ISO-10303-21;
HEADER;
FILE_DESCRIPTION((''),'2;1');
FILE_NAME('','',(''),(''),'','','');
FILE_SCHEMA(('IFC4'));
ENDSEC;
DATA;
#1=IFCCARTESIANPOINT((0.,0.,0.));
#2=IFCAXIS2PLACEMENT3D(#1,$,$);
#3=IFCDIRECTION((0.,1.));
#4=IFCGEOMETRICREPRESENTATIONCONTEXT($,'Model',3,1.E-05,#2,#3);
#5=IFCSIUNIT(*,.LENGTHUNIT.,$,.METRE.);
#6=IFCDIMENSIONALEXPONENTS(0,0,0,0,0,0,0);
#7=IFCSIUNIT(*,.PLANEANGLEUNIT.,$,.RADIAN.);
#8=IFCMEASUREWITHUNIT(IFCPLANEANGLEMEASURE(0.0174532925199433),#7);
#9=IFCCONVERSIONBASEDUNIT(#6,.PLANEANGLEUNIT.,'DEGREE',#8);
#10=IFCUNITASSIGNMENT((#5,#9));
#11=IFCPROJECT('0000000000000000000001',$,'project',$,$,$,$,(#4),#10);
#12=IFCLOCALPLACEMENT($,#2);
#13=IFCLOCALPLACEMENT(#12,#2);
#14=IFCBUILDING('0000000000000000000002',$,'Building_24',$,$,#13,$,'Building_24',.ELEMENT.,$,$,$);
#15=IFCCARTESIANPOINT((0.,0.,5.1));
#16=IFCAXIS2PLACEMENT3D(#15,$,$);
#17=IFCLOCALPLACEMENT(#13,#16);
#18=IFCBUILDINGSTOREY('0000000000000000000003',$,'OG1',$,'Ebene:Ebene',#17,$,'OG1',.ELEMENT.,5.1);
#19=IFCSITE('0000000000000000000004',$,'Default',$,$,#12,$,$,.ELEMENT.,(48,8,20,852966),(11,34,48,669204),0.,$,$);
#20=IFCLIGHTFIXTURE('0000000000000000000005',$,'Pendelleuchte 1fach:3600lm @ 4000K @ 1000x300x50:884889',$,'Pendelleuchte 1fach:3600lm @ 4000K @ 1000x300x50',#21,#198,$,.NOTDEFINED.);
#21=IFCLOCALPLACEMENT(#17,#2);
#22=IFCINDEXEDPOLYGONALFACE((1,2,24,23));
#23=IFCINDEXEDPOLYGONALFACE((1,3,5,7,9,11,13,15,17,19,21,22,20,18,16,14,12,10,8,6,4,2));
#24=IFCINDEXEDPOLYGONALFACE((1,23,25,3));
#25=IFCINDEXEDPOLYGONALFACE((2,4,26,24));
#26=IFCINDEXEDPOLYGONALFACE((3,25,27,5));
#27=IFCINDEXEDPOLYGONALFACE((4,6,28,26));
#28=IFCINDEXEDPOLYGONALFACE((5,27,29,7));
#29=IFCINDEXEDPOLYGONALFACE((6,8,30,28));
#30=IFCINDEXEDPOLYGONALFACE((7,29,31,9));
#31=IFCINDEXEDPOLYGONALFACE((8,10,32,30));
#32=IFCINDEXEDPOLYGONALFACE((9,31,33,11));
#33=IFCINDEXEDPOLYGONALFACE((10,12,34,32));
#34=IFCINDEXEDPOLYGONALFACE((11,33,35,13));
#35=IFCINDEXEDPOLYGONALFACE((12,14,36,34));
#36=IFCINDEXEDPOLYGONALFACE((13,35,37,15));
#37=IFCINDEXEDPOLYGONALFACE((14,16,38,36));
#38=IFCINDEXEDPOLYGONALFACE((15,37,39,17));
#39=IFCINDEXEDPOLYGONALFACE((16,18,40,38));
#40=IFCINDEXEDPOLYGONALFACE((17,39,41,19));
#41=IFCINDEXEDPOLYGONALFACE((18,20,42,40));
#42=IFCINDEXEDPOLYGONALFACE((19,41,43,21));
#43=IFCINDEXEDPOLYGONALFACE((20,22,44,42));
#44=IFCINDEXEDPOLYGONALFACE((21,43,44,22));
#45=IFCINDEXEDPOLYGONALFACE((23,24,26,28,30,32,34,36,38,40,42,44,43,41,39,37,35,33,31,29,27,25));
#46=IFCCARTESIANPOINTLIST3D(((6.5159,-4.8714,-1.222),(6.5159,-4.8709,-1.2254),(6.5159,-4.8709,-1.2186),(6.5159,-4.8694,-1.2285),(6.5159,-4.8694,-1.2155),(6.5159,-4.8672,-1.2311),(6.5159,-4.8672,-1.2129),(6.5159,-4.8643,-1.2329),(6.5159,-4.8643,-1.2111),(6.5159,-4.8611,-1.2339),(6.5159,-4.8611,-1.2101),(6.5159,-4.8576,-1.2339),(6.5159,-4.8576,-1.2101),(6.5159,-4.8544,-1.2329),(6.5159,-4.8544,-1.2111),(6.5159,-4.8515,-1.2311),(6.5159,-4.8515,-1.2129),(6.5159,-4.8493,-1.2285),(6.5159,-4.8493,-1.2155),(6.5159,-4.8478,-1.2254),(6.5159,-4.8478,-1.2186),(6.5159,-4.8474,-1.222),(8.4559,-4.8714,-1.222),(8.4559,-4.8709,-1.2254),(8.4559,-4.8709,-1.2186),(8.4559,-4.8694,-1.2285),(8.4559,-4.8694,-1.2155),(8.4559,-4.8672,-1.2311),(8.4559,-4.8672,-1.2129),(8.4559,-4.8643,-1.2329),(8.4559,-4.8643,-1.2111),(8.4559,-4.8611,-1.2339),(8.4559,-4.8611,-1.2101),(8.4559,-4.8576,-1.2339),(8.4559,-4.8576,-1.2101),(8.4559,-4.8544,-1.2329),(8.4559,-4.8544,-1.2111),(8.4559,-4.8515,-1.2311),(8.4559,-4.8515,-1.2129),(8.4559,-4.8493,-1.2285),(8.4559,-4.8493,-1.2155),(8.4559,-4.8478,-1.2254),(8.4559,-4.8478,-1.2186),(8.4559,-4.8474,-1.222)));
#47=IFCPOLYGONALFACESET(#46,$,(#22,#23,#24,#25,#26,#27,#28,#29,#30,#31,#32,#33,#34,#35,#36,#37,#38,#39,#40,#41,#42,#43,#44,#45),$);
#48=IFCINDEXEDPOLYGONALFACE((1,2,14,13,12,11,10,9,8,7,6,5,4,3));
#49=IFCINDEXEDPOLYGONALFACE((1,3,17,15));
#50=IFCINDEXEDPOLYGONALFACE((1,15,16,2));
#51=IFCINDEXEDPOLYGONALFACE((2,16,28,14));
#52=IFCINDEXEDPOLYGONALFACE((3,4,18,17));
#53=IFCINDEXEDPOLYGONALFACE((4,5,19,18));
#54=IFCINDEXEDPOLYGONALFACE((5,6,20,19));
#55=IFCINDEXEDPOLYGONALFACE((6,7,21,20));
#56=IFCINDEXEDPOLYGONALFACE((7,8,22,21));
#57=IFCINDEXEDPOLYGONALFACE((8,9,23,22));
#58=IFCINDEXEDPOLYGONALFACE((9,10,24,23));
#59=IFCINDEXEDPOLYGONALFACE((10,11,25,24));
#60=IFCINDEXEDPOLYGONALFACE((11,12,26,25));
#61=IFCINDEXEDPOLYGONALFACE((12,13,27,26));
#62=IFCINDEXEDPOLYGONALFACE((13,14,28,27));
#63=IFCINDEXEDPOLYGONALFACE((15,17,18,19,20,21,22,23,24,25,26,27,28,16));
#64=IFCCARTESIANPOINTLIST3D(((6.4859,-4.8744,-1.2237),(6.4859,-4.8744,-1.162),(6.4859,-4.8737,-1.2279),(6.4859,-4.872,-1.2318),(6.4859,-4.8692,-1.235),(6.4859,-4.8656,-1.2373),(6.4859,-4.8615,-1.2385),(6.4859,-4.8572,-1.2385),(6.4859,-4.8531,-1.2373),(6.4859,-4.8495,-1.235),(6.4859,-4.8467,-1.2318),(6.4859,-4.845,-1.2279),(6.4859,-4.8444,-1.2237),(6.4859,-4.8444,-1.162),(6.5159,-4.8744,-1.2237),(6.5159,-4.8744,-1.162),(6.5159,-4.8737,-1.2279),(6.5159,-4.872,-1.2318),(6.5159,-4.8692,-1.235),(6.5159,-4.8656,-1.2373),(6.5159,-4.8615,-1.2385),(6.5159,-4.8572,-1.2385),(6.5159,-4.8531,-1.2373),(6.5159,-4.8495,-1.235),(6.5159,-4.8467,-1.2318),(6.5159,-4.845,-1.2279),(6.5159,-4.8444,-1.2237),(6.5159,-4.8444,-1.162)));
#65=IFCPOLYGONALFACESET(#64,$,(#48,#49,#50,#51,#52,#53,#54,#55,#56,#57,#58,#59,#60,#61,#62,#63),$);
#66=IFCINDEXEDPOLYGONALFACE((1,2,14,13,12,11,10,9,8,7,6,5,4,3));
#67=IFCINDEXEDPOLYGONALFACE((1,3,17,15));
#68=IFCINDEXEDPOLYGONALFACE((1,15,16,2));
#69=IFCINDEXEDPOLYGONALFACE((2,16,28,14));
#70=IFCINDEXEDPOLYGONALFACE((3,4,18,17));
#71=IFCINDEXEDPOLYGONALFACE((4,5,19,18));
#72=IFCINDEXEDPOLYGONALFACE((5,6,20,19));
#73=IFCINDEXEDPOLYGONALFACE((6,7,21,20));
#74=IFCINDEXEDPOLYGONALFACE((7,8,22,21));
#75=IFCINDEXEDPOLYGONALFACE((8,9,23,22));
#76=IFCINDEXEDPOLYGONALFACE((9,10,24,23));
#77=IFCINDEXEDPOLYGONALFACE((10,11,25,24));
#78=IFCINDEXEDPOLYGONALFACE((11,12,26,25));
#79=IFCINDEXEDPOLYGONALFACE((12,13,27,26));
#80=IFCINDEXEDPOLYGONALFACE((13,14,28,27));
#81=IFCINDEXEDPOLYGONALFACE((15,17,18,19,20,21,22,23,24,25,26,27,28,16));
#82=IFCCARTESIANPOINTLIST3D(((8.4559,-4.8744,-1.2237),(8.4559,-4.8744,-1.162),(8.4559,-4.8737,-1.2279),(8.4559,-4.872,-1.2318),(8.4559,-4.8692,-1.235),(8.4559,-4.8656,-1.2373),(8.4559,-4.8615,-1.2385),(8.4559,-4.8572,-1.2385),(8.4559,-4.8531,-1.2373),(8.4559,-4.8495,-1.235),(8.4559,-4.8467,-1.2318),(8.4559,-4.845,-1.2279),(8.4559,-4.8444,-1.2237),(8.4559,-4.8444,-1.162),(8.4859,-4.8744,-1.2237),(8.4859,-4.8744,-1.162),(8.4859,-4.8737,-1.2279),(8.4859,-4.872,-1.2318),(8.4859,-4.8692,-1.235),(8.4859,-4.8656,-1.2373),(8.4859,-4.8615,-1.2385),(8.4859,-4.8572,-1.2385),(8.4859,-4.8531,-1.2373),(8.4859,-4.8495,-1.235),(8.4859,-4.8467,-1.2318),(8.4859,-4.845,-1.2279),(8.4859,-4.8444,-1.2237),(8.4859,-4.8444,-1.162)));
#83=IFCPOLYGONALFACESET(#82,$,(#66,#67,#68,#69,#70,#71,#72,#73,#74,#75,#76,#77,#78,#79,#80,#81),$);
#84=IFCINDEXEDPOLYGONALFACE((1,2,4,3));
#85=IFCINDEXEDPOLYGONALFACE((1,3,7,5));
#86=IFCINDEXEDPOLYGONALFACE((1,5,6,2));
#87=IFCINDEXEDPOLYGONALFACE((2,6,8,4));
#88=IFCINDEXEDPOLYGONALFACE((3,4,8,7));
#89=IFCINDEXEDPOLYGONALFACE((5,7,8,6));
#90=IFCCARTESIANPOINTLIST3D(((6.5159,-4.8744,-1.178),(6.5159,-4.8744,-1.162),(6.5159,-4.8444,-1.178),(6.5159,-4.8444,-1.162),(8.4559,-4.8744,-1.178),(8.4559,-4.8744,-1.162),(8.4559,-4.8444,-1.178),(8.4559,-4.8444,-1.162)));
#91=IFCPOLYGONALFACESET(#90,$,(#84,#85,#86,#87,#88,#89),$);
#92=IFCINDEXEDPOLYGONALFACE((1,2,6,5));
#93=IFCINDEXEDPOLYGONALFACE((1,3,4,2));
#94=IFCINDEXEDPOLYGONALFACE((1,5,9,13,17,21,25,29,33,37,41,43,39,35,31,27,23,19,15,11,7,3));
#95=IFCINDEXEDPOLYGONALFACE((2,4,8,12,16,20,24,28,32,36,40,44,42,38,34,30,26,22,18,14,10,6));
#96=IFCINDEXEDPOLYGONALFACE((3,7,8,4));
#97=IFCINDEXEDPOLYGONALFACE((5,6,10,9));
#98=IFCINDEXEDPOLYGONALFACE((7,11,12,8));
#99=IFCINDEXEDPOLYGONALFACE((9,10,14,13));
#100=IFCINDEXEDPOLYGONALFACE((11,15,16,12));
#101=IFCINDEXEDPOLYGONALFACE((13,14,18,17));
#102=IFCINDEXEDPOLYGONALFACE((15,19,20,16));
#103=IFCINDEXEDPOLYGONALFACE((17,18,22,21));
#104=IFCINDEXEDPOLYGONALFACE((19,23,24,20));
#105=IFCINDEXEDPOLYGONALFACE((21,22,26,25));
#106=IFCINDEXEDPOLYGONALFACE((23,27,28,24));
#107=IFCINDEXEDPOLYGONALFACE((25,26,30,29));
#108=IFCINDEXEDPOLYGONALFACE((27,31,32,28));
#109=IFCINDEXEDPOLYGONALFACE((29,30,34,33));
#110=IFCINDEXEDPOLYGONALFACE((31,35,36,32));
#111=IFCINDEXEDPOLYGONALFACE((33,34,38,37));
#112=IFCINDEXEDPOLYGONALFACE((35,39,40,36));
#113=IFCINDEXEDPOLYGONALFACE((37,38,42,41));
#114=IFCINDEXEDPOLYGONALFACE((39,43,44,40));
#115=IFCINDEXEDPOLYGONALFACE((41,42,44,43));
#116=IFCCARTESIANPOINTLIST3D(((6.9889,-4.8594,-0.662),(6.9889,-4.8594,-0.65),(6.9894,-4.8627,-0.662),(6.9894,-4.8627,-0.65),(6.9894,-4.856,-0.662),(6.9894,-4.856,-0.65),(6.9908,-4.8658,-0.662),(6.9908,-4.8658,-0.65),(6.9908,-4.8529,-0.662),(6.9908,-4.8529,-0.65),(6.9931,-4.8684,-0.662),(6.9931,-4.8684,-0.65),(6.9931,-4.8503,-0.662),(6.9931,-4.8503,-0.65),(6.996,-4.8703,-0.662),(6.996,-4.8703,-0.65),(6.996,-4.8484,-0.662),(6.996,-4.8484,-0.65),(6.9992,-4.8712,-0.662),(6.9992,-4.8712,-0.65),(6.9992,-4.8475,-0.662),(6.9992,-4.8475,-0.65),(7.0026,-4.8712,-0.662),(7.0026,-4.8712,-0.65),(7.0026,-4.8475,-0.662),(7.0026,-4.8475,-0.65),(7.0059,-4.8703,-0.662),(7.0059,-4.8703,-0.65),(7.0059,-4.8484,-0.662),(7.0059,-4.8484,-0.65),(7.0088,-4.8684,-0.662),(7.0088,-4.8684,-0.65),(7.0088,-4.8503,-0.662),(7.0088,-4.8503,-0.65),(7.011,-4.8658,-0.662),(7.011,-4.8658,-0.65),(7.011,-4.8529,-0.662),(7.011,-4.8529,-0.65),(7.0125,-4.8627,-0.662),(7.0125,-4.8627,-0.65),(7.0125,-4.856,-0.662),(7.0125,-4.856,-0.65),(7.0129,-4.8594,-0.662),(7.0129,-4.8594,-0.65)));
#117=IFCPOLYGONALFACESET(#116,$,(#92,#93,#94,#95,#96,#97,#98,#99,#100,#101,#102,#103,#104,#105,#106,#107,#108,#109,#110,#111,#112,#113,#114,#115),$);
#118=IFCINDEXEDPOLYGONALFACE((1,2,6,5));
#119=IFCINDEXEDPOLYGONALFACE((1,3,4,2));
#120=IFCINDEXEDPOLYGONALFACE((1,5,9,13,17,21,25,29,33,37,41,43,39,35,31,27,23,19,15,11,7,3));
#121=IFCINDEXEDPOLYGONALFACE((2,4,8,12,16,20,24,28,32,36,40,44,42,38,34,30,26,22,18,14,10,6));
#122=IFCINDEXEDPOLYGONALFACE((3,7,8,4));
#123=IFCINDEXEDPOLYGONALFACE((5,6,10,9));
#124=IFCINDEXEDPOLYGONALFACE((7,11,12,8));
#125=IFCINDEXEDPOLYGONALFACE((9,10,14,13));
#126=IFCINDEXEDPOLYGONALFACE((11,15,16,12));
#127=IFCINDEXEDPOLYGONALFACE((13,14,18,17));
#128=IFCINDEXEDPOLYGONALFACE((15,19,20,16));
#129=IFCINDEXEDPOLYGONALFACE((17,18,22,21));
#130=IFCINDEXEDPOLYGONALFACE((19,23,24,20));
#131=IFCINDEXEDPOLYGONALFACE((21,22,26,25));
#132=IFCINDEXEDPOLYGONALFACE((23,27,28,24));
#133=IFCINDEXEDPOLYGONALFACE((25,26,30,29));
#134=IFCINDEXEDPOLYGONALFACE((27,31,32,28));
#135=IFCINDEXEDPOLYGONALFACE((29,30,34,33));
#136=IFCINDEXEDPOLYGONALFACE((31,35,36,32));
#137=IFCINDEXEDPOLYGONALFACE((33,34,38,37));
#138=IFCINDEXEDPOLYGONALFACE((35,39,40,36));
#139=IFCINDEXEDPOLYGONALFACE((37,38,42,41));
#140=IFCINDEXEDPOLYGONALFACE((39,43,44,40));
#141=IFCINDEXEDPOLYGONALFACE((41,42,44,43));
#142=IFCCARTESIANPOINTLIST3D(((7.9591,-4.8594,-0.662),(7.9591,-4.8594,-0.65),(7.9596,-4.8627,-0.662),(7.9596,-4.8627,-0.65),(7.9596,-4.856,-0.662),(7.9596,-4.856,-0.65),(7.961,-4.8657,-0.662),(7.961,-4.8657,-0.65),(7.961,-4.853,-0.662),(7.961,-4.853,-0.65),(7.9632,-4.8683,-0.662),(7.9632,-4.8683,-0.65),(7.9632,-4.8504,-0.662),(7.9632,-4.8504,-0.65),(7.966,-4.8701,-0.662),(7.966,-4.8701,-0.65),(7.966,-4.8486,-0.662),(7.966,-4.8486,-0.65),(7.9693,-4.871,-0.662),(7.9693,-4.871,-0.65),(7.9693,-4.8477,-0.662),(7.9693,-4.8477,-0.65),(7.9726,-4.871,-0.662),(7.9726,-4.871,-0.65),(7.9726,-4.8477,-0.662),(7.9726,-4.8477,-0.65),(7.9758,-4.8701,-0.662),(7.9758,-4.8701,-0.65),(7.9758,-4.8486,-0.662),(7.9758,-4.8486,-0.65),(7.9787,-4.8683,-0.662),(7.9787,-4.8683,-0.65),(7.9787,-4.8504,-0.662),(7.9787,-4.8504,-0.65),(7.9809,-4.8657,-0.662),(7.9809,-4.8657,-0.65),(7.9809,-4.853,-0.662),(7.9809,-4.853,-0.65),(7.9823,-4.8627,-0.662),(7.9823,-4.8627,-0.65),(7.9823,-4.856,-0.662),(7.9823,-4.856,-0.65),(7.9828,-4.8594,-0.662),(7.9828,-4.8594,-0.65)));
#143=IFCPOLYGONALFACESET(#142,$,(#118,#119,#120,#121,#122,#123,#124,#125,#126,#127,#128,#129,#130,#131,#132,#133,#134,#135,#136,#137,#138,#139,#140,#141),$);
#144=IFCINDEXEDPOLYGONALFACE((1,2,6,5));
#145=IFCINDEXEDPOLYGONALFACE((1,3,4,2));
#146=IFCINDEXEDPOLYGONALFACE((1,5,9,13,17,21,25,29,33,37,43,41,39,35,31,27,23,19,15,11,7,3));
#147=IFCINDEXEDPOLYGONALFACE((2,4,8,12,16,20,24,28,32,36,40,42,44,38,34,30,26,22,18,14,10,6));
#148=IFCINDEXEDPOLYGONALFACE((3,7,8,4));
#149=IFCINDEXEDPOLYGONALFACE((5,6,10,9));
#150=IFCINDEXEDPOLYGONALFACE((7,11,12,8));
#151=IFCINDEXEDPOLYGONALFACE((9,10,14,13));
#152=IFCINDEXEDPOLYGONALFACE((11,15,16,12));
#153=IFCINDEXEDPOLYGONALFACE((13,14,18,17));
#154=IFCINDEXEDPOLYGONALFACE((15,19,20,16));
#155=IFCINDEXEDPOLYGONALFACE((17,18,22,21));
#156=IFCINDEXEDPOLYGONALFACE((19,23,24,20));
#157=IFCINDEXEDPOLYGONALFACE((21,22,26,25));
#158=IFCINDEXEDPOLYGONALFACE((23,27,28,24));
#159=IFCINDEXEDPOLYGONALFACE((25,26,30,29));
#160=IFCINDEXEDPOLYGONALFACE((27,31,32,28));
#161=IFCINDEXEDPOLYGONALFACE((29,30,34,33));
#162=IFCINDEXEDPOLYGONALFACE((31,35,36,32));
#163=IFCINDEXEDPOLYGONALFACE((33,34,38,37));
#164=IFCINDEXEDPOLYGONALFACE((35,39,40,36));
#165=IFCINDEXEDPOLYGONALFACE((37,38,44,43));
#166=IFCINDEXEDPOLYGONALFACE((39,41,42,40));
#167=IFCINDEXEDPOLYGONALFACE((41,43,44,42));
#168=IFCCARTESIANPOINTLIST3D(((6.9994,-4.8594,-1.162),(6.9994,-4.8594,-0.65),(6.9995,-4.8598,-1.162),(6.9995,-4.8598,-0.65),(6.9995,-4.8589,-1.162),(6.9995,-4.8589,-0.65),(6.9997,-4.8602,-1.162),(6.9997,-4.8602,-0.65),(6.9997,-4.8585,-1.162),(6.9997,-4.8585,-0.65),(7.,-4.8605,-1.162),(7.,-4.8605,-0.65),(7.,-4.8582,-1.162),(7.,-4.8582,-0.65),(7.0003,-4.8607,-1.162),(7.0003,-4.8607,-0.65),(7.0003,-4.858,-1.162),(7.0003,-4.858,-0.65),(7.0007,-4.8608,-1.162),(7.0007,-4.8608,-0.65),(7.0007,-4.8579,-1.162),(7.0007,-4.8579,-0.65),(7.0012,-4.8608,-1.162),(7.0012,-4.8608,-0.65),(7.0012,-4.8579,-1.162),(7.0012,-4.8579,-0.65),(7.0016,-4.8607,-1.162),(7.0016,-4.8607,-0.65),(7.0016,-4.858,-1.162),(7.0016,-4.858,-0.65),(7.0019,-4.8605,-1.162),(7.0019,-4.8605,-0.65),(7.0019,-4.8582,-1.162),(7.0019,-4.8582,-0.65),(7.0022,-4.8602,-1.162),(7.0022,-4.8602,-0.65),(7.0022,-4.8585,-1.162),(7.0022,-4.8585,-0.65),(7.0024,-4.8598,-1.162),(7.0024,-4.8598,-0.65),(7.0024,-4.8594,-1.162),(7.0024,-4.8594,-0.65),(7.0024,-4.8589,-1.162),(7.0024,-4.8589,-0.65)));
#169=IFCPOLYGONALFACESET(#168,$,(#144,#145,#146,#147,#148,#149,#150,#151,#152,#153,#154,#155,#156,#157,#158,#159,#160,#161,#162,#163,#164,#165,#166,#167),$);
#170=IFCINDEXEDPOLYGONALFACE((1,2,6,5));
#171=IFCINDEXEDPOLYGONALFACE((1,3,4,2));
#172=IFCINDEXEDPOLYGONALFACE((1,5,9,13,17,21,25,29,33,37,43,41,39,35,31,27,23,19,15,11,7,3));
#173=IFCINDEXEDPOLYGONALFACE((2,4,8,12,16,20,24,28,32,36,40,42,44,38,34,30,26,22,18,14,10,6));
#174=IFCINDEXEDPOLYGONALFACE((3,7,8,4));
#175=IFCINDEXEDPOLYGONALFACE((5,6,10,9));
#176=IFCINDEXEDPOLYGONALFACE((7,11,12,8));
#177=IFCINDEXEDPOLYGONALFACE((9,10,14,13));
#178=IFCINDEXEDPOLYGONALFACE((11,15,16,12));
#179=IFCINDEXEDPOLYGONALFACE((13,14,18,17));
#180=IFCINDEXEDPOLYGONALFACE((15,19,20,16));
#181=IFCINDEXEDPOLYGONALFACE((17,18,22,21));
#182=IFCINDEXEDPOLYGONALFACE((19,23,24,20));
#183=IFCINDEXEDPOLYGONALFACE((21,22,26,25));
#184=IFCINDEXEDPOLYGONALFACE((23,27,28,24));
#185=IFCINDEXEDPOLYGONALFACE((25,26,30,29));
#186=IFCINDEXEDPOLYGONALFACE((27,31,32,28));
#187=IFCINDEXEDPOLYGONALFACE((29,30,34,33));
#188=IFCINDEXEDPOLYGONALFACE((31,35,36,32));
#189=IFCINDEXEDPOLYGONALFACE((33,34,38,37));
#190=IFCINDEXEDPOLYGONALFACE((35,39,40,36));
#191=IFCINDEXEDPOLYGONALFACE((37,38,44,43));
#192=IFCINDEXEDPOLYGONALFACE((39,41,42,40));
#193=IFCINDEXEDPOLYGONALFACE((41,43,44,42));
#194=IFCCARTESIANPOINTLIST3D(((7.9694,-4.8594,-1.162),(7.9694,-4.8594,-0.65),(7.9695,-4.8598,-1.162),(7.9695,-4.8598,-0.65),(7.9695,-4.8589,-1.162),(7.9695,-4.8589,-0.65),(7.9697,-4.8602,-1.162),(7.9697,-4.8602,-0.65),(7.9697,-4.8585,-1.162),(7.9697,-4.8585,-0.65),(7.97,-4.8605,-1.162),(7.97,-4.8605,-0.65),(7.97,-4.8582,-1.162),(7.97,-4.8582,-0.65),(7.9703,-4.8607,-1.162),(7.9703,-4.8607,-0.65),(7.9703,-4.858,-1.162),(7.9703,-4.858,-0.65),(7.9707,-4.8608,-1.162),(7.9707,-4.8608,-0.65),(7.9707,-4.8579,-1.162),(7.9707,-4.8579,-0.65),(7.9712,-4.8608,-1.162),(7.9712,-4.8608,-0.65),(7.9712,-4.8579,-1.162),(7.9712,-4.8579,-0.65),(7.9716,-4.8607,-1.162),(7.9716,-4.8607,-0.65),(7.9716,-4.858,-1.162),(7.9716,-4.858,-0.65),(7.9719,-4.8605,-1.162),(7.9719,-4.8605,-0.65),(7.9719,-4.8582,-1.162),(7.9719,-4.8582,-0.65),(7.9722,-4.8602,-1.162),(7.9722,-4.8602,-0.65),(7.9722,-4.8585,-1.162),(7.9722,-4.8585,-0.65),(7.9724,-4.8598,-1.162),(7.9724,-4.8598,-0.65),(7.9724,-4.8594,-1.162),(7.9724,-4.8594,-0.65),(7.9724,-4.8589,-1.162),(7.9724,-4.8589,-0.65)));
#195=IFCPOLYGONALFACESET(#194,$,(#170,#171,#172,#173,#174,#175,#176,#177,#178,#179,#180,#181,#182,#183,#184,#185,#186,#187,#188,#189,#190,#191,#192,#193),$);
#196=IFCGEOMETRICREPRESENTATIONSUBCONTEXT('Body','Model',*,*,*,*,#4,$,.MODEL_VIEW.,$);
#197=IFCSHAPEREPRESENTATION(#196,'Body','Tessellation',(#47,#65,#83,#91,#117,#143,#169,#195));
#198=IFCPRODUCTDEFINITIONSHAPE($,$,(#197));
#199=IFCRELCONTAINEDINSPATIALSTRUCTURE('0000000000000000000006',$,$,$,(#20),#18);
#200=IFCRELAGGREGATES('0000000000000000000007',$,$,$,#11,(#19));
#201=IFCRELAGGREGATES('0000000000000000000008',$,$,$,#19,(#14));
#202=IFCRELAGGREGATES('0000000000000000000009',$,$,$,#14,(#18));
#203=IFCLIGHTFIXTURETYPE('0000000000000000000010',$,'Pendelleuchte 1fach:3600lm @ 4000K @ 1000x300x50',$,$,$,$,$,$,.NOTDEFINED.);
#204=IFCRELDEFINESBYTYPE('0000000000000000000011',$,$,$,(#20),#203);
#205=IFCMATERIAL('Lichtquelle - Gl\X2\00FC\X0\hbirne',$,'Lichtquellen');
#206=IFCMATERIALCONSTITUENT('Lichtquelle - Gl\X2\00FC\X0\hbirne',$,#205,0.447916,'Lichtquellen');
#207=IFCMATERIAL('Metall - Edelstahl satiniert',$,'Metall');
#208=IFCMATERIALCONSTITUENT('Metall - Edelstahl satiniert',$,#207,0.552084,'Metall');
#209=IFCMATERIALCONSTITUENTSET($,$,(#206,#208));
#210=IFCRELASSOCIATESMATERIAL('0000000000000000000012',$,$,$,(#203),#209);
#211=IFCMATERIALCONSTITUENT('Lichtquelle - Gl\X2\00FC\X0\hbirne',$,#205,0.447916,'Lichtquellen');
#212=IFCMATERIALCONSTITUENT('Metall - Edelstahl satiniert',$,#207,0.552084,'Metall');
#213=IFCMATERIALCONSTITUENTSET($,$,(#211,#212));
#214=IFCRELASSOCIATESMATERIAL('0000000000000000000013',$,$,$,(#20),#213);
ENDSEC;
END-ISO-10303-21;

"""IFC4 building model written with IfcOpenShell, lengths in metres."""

from ifc_helpers import new_model, entity, si_unit, converted_unit, direction, frame, origin, place, context, subcontext, project, spatial, line, arc, indexed_curve, outline, extrude, source, transform, mapped, material, constituent, constituent_set, type_object, type_shapes, element, save


model = new_model("IFC4")

# Units and contexts
model_context = context("Model", 3, precision=1e-05, world=origin(), true_north=direction((0.0, 1.0)))
body_context = subcontext(model_context, "Body", "Model", "MODEL_VIEW")
ifc_project = project(units=[si_unit("LENGTHUNIT", "METRE"), converted_unit("PLANEANGLEUNIT", "DEGREE", entity("IfcPlaneAngleMeasure", 0.0174532925199433), si_unit("PLANEANGLEUNIT", "RADIAN"), dimensions=[0, 0, 0, 0, 0, 0, 0])], contexts=[model_context])

# Site, building, storey
site_placement = place(None, origin())
site = spatial("IfcSite", under=ifc_project, at=site_placement, Name="Default", CompositionType="ELEMENT", RefLatitude=(48, 8, 20, 852966), RefLongitude=(11, 34, 48, 669204), RefElevation=0.0)
building_placement = place(site_placement, origin())
building = spatial("IfcBuilding", under=site, at=building_placement, Name="Building_24", LongName="Building_24", CompositionType="ELEMENT")
storey_placement = place(building_placement, frame((0.0, 0.0, 5.1)))
storey = spatial("IfcBuildingStorey", under=building, at=storey_placement, Name="OG1", ObjectType="Ebene:Ebene", LongName="OG1", CompositionType="ELEMENT", Elevation=5.1)

# Light fixture
ifc_material_1 = material(Name="Lichtquelle - Glühbirne", Category="Lichtquellen")
ifc_material_2 = material(Name="Metall - Edelstahl satiniert", Category="Metall")
ifc_constituent_1 = constituent(ifc_material_1, Name="Lichtquelle - Glühbirne", Category="Lichtquellen", fraction=0.447916)
ifc_constituent_2 = constituent(ifc_material_2, Name="Metall - Edelstahl satiniert", Category="Metall", fraction=0.552084)
ifc_constituent_set_1 = constituent_set(constituents=[ifc_constituent_1, ifc_constituent_2])
light_fixture_type_1 = type_object("IfcLightFixtureType", Name="Pendelleuchte 1fach:3600lm @ 4000K @ 1000x300x50", PredefinedType="NOTDEFINED", material=ifc_constituent_set_1)
shared_shape_1 = source(origin(), body_context, "Body", "SweptSolid", [
    extrude(outline(indexed_curve([(-0.012, 0.0), (0.0, -0.012), (0.012, 0.0), (0.0, 0.012)], segments=[arc(1, 2, 3), arc(3, 4, 1)], self_intersect=False)), frame((-0.97, 0.0, -0.572), z_axis=(1.0, 0.0, 0.0), x_axis=(0.0, -1.0, 0.0)), (0.0, 0.0, 1.0), 1.94),
    extrude(outline(indexed_curve([(0.015, 0.0308), (0.0, 0.0458), (-0.015, 0.0308), (-0.015, -0.0308), (0.015, -0.0308)], segments=[arc(1, 2, 3), line(3, 4, 5, 1)], self_intersect=False)), frame((0.97, 0.0, -0.5428), z_axis=(1.0, 0.0, 0.0), x_axis=(0.0, -1.0, 0.0)), (0.0, 0.0, 1.0), 0.03),
    extrude(outline(indexed_curve([(0.015, 0.0308), (0.0, 0.0458), (-0.015, 0.0308), (-0.015, -0.0308), (0.015, -0.0308)], segments=[arc(1, 2, 3), line(3, 4, 5, 1)], self_intersect=False)), frame((-1.0, 0.0, -0.5428), z_axis=(1.0, 0.0, 0.0), x_axis=(0.0, -1.0, 0.0)), (0.0, 0.0, 1.0), 0.03),
    extrude(outline(indexed_curve([(-0.015, -0.97), (0.015, -0.97), (0.015, 0.97), (-0.015, 0.97), (-0.015, -0.97)], self_intersect=False)), frame((0.0, 0.0, -0.528), z_axis=(0.0, 0.0, 1.0), x_axis=(0.0, 1.0, 0.0)), (0.0, 0.0, 1.0), 0.016),
    extrude(outline(indexed_curve([(-0.012, 0.0), (0.0, -0.012), (0.012, 0.0), (0.0, 0.012)], segments=[arc(1, 2, 3), arc(3, 4, 1)], self_intersect=False)), frame((0.485, 0.0, -0.012)), (0.0, 0.0, 1.0), 0.012),
    extrude(outline(indexed_curve([(-0.0118, 0.0), (0.0, -0.0118), (0.0118, 0.0), (0.0, 0.0118)], segments=[arc(1, 2, 3), arc(3, 4, 1)], self_intersect=False)), frame((-0.485, 0.0, -0.012)), (0.0, 0.0, 1.0), 0.012),
    extrude(outline(indexed_curve([(-0.0015, 0.0), (0.0, -0.0015), (0.0015, 0.0), (0.0, 0.0015)], segments=[arc(1, 2, 3), arc(3, 4, 1)], self_intersect=False)), frame((0.485, 0.0, -0.512)), (0.0, 0.0, 1.0), 0.512),
    extrude(outline(indexed_curve([(-0.0015, 0.0), (0.0, -0.0015), (0.0015, 0.0), (0.0, 0.0015)], segments=[arc(1, 2, 3), arc(3, 4, 1)], self_intersect=False)), frame((-0.485, 0.0, -0.512)), (0.0, 0.0, 1.0), 0.512),
])
type_shapes(light_fixture_type_1, [shared_shape_1])
ifc_constituent_3 = constituent(ifc_material_1, Name="Lichtquelle - Glühbirne", Category="Lichtquellen", fraction=0.447916)
ifc_constituent_4 = constituent(ifc_material_2, Name="Metall - Edelstahl satiniert", Category="Metall", fraction=0.552084)
ifc_constituent_set_2 = constituent_set(constituents=[ifc_constituent_3, ifc_constituent_4])
light_fixture_1_placement = place(storey_placement, frame((7.4859, -4.8594, -0.65), z_axis=(0.0, 0.0, 1.0), x_axis=(-1.0, 0.0, 0.0)))
element("IfcLightFixture", 1, at=light_fixture_1_placement, inside=storey, type_object=light_fixture_type_1, material=ifc_constituent_set_2, Name="Pendelleuchte 1fach:3600lm @ 4000K @ 1000x300x50:884889", ObjectType="Pendelleuchte 1fach:3600lm @ 4000K @ 1000x300x50", PredefinedType="NOTDEFINED", context=body_context, shape_type="MappedRepresentation", body=[
    mapped(shared_shape_1, transform((0.0, 0.0, 0.0), scale=1.0)),
])

save(model, "model.ifc")
